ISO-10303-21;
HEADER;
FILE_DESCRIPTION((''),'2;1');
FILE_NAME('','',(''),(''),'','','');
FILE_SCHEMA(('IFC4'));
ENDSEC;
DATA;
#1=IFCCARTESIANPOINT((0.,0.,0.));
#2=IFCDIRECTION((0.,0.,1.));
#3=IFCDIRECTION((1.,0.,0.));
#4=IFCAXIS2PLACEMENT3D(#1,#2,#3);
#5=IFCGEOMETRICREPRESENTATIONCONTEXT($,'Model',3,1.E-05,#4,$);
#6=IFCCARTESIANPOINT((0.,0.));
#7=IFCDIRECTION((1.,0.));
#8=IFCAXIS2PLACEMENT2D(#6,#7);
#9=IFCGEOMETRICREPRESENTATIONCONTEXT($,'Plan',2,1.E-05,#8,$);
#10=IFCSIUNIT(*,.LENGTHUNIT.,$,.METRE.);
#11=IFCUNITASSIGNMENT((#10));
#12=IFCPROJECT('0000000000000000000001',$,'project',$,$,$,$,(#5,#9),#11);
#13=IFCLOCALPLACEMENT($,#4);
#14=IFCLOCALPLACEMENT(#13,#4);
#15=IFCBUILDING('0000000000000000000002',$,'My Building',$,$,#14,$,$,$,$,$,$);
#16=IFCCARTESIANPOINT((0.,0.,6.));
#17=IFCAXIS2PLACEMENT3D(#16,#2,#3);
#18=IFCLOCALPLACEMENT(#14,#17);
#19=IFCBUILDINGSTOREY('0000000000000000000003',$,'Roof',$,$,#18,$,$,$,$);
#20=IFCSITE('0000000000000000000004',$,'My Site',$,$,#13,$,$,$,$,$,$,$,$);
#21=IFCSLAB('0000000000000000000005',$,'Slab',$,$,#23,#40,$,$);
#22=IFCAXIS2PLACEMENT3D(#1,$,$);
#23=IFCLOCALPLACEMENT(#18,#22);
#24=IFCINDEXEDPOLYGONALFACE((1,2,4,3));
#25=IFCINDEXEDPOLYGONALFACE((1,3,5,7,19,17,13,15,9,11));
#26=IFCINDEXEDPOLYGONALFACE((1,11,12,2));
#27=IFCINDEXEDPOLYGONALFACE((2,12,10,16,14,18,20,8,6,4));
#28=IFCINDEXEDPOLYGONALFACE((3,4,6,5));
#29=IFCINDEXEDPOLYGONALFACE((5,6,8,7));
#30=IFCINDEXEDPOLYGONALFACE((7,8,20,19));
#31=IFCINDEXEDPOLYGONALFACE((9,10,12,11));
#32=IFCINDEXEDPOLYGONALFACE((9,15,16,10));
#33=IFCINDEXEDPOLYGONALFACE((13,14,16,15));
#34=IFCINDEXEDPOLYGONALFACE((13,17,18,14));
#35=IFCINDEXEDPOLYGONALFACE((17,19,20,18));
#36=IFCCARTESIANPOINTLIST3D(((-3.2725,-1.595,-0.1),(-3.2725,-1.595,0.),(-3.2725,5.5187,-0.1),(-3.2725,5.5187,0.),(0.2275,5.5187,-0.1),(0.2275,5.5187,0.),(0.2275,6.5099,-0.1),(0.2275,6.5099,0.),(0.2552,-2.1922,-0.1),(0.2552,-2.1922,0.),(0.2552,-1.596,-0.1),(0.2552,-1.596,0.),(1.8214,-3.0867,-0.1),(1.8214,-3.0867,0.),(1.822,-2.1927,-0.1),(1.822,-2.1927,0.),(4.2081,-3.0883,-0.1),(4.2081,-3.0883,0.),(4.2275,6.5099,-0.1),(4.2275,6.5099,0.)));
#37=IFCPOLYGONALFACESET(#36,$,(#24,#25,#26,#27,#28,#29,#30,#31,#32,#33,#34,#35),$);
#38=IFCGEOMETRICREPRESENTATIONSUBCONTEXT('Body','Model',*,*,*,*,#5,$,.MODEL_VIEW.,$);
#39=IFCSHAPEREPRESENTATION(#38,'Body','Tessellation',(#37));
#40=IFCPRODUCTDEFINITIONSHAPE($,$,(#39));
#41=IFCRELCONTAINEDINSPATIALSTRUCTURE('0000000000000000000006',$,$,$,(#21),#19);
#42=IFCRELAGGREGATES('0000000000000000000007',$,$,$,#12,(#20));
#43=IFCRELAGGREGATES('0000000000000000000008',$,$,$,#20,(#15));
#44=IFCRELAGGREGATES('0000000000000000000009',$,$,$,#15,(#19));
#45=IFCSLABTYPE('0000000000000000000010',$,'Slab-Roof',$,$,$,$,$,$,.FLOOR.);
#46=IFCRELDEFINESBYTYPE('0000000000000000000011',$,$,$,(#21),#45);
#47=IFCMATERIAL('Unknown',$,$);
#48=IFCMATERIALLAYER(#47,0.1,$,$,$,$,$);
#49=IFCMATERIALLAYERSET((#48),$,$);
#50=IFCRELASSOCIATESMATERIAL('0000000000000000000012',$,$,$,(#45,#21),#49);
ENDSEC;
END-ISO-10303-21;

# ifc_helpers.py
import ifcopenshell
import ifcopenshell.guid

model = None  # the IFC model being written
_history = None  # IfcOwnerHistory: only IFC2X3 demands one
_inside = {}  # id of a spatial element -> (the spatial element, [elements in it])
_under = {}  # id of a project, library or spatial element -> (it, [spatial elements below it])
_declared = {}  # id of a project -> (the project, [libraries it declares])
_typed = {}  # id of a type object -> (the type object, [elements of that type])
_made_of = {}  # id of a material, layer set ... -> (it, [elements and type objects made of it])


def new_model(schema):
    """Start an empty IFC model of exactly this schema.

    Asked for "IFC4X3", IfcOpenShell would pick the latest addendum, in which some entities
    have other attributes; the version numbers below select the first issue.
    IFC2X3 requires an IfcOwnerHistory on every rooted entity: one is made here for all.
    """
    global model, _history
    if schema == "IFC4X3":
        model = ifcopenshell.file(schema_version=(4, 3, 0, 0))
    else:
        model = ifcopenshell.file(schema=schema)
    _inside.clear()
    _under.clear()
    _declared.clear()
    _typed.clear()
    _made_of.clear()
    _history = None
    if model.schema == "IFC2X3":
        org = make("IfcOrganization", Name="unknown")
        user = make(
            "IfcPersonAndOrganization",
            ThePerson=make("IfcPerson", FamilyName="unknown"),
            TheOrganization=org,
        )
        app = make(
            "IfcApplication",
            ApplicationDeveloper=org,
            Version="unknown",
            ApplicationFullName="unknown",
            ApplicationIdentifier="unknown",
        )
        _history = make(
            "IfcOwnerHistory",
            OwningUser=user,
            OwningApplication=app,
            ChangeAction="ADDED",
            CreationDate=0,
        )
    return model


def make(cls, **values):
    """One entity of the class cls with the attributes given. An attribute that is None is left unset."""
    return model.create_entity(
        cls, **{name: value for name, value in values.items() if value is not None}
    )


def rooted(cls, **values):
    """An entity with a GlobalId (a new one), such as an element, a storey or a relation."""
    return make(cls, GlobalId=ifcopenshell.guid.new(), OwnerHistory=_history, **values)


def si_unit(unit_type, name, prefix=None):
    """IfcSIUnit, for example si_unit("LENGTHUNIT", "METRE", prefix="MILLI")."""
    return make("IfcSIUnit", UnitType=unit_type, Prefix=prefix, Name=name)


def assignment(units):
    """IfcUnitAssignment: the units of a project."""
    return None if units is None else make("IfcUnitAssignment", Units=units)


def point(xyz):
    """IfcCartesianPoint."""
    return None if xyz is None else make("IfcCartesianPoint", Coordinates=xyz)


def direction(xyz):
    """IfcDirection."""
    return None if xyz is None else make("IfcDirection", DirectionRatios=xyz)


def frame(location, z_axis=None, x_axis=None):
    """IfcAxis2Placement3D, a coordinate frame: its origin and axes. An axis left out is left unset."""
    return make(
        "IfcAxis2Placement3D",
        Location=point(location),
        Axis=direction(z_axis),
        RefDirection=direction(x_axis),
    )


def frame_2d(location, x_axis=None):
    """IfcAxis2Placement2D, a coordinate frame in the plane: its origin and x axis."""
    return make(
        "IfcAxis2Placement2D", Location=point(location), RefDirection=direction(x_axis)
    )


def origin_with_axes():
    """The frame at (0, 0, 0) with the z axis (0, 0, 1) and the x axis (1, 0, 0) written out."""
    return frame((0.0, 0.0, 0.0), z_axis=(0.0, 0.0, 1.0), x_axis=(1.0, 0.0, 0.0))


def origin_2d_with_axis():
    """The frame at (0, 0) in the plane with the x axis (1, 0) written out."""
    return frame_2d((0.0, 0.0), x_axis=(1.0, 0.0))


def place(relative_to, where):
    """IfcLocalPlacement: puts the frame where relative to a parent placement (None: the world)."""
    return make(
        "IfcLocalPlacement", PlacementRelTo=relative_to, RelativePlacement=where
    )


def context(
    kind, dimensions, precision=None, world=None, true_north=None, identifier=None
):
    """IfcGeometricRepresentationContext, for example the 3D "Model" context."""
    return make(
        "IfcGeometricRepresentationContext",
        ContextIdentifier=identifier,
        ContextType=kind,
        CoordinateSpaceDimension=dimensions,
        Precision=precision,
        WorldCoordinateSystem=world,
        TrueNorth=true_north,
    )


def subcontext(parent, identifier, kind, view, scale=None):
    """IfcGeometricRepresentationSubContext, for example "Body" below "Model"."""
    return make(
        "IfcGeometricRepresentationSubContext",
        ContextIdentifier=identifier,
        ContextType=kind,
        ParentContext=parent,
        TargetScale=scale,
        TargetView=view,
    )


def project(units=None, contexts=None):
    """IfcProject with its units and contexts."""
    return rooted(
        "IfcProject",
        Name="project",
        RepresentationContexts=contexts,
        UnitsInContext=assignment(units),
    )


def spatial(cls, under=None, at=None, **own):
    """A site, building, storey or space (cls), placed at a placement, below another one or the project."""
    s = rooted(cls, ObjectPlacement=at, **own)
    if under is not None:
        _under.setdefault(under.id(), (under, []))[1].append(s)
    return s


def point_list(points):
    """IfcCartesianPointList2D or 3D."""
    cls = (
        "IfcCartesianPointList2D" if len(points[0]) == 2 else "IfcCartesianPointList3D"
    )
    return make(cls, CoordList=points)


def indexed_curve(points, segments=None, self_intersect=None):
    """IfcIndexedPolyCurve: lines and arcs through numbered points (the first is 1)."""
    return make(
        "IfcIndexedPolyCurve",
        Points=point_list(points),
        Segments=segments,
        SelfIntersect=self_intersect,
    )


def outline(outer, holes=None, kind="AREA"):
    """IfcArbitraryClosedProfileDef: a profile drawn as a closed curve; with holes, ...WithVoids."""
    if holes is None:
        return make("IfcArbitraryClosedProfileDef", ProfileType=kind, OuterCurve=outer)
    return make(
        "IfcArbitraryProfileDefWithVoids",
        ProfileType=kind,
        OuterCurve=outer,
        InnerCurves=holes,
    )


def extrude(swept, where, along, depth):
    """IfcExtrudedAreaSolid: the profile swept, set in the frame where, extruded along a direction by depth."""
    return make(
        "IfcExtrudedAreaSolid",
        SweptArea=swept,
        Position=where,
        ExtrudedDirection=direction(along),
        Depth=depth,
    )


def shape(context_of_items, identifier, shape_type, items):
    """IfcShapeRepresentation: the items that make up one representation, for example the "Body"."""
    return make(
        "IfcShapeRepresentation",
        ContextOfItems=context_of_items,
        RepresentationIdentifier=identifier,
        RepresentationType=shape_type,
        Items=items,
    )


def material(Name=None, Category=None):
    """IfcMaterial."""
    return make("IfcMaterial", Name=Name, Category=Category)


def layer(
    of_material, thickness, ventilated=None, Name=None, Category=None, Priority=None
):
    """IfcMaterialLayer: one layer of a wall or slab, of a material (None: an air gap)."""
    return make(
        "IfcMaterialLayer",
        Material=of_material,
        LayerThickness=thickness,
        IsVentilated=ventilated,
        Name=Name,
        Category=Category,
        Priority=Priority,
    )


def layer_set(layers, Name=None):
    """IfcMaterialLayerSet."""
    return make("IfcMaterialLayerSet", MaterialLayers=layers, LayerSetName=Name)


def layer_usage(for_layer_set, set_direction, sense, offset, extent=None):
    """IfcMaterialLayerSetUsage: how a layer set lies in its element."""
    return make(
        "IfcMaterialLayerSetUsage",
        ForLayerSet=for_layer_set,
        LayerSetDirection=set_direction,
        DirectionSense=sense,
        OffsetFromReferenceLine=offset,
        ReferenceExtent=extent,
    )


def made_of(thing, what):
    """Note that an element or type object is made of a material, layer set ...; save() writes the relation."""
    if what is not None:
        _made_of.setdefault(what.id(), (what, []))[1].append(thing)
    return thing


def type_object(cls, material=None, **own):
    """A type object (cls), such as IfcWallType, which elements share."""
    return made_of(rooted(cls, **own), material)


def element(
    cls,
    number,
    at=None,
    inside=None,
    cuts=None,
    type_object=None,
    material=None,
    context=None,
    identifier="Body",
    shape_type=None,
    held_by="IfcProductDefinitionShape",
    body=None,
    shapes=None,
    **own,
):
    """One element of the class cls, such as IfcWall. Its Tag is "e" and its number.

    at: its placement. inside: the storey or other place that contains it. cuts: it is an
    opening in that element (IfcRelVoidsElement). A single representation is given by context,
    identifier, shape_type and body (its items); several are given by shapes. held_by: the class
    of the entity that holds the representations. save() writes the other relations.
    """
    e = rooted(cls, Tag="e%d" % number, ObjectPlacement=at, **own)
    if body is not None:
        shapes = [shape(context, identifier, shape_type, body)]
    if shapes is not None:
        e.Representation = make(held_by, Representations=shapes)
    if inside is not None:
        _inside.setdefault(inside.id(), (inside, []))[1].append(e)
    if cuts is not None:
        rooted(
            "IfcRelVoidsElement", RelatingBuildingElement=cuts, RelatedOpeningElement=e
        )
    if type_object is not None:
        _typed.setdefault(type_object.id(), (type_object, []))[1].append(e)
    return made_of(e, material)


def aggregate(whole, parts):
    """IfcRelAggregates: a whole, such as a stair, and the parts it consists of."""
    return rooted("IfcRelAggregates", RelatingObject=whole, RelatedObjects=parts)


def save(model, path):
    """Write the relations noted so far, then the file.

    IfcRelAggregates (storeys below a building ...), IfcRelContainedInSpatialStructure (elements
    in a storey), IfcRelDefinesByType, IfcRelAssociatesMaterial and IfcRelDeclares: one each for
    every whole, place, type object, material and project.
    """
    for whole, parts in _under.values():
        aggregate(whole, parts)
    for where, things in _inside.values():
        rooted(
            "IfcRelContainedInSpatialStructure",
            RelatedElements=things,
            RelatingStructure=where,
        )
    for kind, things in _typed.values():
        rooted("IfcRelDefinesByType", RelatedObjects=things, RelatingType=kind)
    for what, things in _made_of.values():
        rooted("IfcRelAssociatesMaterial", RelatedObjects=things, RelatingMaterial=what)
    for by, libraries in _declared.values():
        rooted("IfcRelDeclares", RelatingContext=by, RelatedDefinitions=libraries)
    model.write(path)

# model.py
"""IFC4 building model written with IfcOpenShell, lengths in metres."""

from ifc_helpers import new_model, si_unit, frame, origin_with_axes, origin_2d_with_axis, place, context, subcontext, project, spatial, indexed_curve, outline, extrude, material, layer, layer_set, layer_usage, type_object, element, save


model = new_model("IFC4")

# Units and contexts
model_context = context("Model", 3, precision=1e-05, world=origin_with_axes())
plan_context = context("Plan", 2, precision=1e-05, world=origin_2d_with_axis())
body_context = subcontext(model_context, "Body", "Model", "MODEL_VIEW")
ifc_project = project(units=[si_unit("LENGTHUNIT", "METRE")], contexts=[model_context, plan_context])

# Site, building, storey
site_placement = place(None, origin_with_axes())
site = spatial("IfcSite", under=ifc_project, at=site_placement, Name="My Site")
building_placement = place(site_placement, origin_with_axes())
building = spatial("IfcBuilding", under=site, at=building_placement, Name="My Building")
storey_placement = place(building_placement, frame((0.0, 0.0, 6.0), z_axis=(0.0, 0.0, 1.0), x_axis=(1.0, 0.0, 0.0)))
storey = spatial("IfcBuildingStorey", under=building, at=storey_placement, Name="Roof")

# Slab
ifc_material = material(Name="Unknown")
ifc_layer = layer(ifc_material, 0.1)
ifc_layer_set = layer_set([ifc_layer])
ifc_layer_usage = layer_usage(ifc_layer_set, "AXIS3", "POSITIVE", -0.1)
slab_type = type_object("IfcSlabType", Name="Slab-Roof", PredefinedType="FLOOR", material=ifc_layer_set)
slab_placement = place(storey_placement, frame((4.2275, 6.5099, 0.0), z_axis=(0.0, 0.0, 1.0), x_axis=(1.0, 0.0, 0.0)))
element("IfcSlab", 1, at=slab_placement, inside=storey, type_object=slab_type, material=ifc_layer_usage, Name="Slab", context=body_context, shape_type="SweptSolid", body=[
    extrude(outline(indexed_curve([(0.0, 0.0), (-4.0, 0.0), (-4.0, -0.9913), (-7.5, -0.9913), (-7.5, -8.1049), (-3.9723, -8.1059), (-3.9723, -8.7022), (-2.4055, -8.7026), (-2.4061, -9.5967), (-0.0194, -9.5982), (0.0, 0.0)])), frame((0.0, 0.0, -0.1), z_axis=(0.0, 0.0, 1.0), x_axis=(1.0, 0.0, 0.0)), (0.0, 0.0, 1.0), 0.1),
])

save(model, "model.ifc")
